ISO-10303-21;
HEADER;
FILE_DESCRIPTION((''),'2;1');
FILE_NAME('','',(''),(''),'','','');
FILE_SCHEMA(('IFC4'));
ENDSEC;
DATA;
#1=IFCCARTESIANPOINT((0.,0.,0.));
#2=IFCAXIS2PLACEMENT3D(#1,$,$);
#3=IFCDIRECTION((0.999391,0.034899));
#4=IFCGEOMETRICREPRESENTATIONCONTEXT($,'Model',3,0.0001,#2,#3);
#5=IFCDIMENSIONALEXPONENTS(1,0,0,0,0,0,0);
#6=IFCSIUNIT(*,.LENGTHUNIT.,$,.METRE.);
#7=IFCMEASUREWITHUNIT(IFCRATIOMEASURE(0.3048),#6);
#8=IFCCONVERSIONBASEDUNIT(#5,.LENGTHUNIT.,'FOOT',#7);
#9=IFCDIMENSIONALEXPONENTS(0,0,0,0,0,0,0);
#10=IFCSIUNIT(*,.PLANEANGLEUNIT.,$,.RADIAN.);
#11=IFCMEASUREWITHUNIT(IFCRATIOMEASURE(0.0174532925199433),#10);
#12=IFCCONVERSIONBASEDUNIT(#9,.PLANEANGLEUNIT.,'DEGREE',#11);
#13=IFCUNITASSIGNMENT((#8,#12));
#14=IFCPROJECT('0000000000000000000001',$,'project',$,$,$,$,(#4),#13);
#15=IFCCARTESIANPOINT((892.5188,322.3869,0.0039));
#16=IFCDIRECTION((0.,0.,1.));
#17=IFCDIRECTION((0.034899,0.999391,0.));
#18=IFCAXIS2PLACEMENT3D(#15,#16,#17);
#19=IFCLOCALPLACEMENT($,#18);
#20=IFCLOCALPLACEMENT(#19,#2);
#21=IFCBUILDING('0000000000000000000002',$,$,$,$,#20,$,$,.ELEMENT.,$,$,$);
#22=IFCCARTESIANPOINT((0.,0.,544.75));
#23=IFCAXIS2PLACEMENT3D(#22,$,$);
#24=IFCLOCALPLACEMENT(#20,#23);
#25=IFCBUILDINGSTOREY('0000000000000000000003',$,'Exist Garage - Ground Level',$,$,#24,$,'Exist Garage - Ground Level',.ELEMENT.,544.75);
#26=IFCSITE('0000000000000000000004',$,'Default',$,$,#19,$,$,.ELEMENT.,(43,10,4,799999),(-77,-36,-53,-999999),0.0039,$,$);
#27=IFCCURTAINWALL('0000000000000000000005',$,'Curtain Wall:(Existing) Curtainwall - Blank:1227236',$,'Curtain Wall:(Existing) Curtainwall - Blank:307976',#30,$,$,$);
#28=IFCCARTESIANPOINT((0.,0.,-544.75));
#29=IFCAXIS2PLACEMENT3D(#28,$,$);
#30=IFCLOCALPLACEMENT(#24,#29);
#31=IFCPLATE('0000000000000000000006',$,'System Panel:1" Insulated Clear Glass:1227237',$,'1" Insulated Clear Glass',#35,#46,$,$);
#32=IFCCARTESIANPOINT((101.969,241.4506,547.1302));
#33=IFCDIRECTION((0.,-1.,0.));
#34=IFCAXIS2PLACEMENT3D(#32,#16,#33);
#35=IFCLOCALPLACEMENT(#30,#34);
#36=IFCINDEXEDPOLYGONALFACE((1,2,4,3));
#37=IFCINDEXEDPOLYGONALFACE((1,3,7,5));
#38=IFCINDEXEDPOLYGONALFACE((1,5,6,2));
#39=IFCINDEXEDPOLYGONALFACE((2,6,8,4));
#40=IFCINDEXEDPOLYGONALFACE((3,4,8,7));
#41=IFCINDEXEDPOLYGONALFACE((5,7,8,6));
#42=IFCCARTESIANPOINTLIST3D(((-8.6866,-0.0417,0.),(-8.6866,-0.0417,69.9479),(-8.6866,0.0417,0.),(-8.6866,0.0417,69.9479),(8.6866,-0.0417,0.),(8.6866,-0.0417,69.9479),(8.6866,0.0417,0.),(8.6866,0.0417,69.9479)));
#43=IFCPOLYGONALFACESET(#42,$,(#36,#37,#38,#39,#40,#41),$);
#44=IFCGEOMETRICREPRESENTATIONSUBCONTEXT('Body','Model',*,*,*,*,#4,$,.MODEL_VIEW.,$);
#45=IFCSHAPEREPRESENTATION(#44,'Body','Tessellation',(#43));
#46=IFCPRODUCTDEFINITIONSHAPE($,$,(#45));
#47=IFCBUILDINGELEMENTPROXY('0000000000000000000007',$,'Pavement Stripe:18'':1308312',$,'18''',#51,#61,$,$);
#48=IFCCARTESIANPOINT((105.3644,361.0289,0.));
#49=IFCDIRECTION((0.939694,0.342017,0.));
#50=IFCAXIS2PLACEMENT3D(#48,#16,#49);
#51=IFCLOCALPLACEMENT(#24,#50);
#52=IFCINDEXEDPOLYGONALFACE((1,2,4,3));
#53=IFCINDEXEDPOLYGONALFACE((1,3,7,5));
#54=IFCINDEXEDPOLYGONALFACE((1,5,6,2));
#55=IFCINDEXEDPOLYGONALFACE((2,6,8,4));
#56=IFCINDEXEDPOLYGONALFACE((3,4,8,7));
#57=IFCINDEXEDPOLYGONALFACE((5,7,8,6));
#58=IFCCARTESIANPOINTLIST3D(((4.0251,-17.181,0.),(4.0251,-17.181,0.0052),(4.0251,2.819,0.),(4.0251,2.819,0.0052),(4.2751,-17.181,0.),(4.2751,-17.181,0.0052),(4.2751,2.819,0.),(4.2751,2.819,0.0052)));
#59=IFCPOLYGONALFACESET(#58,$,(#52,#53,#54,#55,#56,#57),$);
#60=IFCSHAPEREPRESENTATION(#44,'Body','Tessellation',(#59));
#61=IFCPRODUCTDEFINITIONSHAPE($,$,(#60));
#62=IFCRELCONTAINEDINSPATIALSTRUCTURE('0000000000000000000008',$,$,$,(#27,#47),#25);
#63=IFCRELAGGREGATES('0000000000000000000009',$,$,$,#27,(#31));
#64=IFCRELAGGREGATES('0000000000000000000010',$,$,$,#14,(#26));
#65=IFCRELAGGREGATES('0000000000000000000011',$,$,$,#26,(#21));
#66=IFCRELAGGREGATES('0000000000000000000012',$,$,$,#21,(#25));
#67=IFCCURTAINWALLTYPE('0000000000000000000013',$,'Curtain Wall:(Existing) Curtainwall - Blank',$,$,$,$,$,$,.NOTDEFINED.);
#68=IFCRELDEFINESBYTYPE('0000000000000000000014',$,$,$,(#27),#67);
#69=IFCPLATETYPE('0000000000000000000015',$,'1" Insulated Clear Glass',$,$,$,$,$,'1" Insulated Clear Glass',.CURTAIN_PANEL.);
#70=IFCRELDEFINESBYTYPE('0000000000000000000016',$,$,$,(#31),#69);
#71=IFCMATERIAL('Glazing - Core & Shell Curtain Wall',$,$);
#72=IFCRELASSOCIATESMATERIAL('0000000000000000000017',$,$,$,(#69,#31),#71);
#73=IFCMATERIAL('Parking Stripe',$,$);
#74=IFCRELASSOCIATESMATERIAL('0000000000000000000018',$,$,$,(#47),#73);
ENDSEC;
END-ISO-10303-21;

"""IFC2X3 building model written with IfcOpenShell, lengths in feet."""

from ifc_helpers import new_model, entity, si_unit, converted_unit, direction, frame, frame_2d, origin, origin_2d_with_axis, place, context, subcontext, project, spatial, rectangle, extrude, source, transform, mapped, material, type_object, type_shapes, element, aggregate, save


model = new_model("IFC2X3")

# Units and contexts
model_context = context("Model", 3, precision=0.0001, world=origin(), true_north=direction((0.999391, 0.034899)))
body_context = subcontext(model_context, "Body", "Model", "MODEL_VIEW")
ifc_project = project(units=[converted_unit("LENGTHUNIT", "FOOT", entity("IfcRatioMeasure", 0.3048), si_unit("LENGTHUNIT", "METRE"), dimensions=[1, 0, 0, 0, 0, 0, 0]), converted_unit("PLANEANGLEUNIT", "DEGREE", entity("IfcRatioMeasure", 0.0174532925199433), si_unit("PLANEANGLEUNIT", "RADIAN"), dimensions=[0, 0, 0, 0, 0, 0, 0])], contexts=[model_context])

# Site, building, storey
site_placement = place(None, frame((892.5188, 322.3869, 0.0039), z_axis=(0.0, 0.0, 1.0), x_axis=(0.034899, 0.999391, 0.0)))
site = spatial("IfcSite", under=ifc_project, at=site_placement, Name="Default", CompositionType="ELEMENT", RefLatitude=(43, 10, 4, 799999), RefLongitude=(-77, -36, -53, -999999), RefElevation=0.0039)
building_placement = place(site_placement, origin())
building = spatial("IfcBuilding", under=site, at=building_placement, CompositionType="ELEMENT")
storey_placement = place(building_placement, frame((0.0, 0.0, 544.75)))
storey = spatial("IfcBuildingStorey", under=building, at=storey_placement, Name="Exist Garage - Ground Level", LongName="Exist Garage - Ground Level", CompositionType="ELEMENT", Elevation=544.75)

# Curtain wall, plate
curtain_wall_type = type_object("IfcCurtainWallType", Name="Curtain Wall:(Existing) Curtainwall - Blank", PredefinedType="NOTDEFINED")
curtain_wall_placement = place(storey_placement, frame((0.0, 0.0, -544.75)))
curtain_wall = element("IfcCurtainWall", 1, at=curtain_wall_placement, inside=storey, type_object=curtain_wall_type, Name="Curtain Wall:(Existing) Curtainwall - Blank:1227236", ObjectType="Curtain Wall:(Existing) Curtainwall - Blank:307976")
ifc_material_1 = material(Name="Glazing - Core & Shell Curtain Wall")
plate_type = type_object("IfcPlateType", Name="1\" Insulated Clear Glass", ElementType="1\" Insulated Clear Glass", PredefinedType="CURTAIN_PANEL", material=ifc_material_1)
shared_shape_1 = source(origin(), body_context, "Body", "SweptSolid", [
    extrude(rectangle(XDim=0.0833, YDim=17.3733, at=origin_2d_with_axis()), frame((0.0, 0.0, 0.0), z_axis=(0.0, 0.0, 1.0), x_axis=(0.0, 1.0, 0.0)), (0.0, 0.0, 1.0), 69.9479),
])
type_shapes(plate_type, [shared_shape_1])
plate_placement = place(curtain_wall_placement, frame((101.969, 241.4506, 547.1302), z_axis=(0.0, 0.0, 1.0), x_axis=(0.0, -1.0, 0.0)))
plate = element("IfcPlate", 2, at=plate_placement, type_object=plate_type, material=ifc_material_1, Name="System Panel:1\" Insulated Clear Glass:1227237", ObjectType="1\" Insulated Clear Glass", context=body_context, shape_type="MappedRepresentation", body=[
    mapped(shared_shape_1, transform((0.0, 0.0, 0.0), scale=1.0)),
])
aggregate(curtain_wall, [plate])

# Building element proxy
ifc_material_2 = material(Name="Parking Stripe")
shared_shape_2 = source(origin(), body_context, "Body", "SweptSolid", [
    extrude(rectangle(XDim=0.25, YDim=20.0, at=frame_2d((0.0, 0.0), x_axis=(1.0, 0.0))), frame((4.1501, -7.181, 0.0), z_axis=(0.0, 0.0, 1.0), x_axis=(-1.0, 0.0, 0.0)), (0.0, 0.0, 1.0), 0.0052),
])
proxy_placement = place(storey_placement, frame((105.3644, 361.0289, 0.0), z_axis=(0.0, 0.0, 1.0), x_axis=(0.939694, 0.342017, 0.0)))
element("IfcBuildingElementProxy", 3, at=proxy_placement, inside=storey, material=ifc_material_2, Name="Pavement Stripe:18':1308312", ObjectType="18'", context=body_context, shape_type="MappedRepresentation", body=[
    mapped(shared_shape_2, transform((0.0, 0.0, 0.0), scale=1.0)),
])

save(model, "model.ifc")
